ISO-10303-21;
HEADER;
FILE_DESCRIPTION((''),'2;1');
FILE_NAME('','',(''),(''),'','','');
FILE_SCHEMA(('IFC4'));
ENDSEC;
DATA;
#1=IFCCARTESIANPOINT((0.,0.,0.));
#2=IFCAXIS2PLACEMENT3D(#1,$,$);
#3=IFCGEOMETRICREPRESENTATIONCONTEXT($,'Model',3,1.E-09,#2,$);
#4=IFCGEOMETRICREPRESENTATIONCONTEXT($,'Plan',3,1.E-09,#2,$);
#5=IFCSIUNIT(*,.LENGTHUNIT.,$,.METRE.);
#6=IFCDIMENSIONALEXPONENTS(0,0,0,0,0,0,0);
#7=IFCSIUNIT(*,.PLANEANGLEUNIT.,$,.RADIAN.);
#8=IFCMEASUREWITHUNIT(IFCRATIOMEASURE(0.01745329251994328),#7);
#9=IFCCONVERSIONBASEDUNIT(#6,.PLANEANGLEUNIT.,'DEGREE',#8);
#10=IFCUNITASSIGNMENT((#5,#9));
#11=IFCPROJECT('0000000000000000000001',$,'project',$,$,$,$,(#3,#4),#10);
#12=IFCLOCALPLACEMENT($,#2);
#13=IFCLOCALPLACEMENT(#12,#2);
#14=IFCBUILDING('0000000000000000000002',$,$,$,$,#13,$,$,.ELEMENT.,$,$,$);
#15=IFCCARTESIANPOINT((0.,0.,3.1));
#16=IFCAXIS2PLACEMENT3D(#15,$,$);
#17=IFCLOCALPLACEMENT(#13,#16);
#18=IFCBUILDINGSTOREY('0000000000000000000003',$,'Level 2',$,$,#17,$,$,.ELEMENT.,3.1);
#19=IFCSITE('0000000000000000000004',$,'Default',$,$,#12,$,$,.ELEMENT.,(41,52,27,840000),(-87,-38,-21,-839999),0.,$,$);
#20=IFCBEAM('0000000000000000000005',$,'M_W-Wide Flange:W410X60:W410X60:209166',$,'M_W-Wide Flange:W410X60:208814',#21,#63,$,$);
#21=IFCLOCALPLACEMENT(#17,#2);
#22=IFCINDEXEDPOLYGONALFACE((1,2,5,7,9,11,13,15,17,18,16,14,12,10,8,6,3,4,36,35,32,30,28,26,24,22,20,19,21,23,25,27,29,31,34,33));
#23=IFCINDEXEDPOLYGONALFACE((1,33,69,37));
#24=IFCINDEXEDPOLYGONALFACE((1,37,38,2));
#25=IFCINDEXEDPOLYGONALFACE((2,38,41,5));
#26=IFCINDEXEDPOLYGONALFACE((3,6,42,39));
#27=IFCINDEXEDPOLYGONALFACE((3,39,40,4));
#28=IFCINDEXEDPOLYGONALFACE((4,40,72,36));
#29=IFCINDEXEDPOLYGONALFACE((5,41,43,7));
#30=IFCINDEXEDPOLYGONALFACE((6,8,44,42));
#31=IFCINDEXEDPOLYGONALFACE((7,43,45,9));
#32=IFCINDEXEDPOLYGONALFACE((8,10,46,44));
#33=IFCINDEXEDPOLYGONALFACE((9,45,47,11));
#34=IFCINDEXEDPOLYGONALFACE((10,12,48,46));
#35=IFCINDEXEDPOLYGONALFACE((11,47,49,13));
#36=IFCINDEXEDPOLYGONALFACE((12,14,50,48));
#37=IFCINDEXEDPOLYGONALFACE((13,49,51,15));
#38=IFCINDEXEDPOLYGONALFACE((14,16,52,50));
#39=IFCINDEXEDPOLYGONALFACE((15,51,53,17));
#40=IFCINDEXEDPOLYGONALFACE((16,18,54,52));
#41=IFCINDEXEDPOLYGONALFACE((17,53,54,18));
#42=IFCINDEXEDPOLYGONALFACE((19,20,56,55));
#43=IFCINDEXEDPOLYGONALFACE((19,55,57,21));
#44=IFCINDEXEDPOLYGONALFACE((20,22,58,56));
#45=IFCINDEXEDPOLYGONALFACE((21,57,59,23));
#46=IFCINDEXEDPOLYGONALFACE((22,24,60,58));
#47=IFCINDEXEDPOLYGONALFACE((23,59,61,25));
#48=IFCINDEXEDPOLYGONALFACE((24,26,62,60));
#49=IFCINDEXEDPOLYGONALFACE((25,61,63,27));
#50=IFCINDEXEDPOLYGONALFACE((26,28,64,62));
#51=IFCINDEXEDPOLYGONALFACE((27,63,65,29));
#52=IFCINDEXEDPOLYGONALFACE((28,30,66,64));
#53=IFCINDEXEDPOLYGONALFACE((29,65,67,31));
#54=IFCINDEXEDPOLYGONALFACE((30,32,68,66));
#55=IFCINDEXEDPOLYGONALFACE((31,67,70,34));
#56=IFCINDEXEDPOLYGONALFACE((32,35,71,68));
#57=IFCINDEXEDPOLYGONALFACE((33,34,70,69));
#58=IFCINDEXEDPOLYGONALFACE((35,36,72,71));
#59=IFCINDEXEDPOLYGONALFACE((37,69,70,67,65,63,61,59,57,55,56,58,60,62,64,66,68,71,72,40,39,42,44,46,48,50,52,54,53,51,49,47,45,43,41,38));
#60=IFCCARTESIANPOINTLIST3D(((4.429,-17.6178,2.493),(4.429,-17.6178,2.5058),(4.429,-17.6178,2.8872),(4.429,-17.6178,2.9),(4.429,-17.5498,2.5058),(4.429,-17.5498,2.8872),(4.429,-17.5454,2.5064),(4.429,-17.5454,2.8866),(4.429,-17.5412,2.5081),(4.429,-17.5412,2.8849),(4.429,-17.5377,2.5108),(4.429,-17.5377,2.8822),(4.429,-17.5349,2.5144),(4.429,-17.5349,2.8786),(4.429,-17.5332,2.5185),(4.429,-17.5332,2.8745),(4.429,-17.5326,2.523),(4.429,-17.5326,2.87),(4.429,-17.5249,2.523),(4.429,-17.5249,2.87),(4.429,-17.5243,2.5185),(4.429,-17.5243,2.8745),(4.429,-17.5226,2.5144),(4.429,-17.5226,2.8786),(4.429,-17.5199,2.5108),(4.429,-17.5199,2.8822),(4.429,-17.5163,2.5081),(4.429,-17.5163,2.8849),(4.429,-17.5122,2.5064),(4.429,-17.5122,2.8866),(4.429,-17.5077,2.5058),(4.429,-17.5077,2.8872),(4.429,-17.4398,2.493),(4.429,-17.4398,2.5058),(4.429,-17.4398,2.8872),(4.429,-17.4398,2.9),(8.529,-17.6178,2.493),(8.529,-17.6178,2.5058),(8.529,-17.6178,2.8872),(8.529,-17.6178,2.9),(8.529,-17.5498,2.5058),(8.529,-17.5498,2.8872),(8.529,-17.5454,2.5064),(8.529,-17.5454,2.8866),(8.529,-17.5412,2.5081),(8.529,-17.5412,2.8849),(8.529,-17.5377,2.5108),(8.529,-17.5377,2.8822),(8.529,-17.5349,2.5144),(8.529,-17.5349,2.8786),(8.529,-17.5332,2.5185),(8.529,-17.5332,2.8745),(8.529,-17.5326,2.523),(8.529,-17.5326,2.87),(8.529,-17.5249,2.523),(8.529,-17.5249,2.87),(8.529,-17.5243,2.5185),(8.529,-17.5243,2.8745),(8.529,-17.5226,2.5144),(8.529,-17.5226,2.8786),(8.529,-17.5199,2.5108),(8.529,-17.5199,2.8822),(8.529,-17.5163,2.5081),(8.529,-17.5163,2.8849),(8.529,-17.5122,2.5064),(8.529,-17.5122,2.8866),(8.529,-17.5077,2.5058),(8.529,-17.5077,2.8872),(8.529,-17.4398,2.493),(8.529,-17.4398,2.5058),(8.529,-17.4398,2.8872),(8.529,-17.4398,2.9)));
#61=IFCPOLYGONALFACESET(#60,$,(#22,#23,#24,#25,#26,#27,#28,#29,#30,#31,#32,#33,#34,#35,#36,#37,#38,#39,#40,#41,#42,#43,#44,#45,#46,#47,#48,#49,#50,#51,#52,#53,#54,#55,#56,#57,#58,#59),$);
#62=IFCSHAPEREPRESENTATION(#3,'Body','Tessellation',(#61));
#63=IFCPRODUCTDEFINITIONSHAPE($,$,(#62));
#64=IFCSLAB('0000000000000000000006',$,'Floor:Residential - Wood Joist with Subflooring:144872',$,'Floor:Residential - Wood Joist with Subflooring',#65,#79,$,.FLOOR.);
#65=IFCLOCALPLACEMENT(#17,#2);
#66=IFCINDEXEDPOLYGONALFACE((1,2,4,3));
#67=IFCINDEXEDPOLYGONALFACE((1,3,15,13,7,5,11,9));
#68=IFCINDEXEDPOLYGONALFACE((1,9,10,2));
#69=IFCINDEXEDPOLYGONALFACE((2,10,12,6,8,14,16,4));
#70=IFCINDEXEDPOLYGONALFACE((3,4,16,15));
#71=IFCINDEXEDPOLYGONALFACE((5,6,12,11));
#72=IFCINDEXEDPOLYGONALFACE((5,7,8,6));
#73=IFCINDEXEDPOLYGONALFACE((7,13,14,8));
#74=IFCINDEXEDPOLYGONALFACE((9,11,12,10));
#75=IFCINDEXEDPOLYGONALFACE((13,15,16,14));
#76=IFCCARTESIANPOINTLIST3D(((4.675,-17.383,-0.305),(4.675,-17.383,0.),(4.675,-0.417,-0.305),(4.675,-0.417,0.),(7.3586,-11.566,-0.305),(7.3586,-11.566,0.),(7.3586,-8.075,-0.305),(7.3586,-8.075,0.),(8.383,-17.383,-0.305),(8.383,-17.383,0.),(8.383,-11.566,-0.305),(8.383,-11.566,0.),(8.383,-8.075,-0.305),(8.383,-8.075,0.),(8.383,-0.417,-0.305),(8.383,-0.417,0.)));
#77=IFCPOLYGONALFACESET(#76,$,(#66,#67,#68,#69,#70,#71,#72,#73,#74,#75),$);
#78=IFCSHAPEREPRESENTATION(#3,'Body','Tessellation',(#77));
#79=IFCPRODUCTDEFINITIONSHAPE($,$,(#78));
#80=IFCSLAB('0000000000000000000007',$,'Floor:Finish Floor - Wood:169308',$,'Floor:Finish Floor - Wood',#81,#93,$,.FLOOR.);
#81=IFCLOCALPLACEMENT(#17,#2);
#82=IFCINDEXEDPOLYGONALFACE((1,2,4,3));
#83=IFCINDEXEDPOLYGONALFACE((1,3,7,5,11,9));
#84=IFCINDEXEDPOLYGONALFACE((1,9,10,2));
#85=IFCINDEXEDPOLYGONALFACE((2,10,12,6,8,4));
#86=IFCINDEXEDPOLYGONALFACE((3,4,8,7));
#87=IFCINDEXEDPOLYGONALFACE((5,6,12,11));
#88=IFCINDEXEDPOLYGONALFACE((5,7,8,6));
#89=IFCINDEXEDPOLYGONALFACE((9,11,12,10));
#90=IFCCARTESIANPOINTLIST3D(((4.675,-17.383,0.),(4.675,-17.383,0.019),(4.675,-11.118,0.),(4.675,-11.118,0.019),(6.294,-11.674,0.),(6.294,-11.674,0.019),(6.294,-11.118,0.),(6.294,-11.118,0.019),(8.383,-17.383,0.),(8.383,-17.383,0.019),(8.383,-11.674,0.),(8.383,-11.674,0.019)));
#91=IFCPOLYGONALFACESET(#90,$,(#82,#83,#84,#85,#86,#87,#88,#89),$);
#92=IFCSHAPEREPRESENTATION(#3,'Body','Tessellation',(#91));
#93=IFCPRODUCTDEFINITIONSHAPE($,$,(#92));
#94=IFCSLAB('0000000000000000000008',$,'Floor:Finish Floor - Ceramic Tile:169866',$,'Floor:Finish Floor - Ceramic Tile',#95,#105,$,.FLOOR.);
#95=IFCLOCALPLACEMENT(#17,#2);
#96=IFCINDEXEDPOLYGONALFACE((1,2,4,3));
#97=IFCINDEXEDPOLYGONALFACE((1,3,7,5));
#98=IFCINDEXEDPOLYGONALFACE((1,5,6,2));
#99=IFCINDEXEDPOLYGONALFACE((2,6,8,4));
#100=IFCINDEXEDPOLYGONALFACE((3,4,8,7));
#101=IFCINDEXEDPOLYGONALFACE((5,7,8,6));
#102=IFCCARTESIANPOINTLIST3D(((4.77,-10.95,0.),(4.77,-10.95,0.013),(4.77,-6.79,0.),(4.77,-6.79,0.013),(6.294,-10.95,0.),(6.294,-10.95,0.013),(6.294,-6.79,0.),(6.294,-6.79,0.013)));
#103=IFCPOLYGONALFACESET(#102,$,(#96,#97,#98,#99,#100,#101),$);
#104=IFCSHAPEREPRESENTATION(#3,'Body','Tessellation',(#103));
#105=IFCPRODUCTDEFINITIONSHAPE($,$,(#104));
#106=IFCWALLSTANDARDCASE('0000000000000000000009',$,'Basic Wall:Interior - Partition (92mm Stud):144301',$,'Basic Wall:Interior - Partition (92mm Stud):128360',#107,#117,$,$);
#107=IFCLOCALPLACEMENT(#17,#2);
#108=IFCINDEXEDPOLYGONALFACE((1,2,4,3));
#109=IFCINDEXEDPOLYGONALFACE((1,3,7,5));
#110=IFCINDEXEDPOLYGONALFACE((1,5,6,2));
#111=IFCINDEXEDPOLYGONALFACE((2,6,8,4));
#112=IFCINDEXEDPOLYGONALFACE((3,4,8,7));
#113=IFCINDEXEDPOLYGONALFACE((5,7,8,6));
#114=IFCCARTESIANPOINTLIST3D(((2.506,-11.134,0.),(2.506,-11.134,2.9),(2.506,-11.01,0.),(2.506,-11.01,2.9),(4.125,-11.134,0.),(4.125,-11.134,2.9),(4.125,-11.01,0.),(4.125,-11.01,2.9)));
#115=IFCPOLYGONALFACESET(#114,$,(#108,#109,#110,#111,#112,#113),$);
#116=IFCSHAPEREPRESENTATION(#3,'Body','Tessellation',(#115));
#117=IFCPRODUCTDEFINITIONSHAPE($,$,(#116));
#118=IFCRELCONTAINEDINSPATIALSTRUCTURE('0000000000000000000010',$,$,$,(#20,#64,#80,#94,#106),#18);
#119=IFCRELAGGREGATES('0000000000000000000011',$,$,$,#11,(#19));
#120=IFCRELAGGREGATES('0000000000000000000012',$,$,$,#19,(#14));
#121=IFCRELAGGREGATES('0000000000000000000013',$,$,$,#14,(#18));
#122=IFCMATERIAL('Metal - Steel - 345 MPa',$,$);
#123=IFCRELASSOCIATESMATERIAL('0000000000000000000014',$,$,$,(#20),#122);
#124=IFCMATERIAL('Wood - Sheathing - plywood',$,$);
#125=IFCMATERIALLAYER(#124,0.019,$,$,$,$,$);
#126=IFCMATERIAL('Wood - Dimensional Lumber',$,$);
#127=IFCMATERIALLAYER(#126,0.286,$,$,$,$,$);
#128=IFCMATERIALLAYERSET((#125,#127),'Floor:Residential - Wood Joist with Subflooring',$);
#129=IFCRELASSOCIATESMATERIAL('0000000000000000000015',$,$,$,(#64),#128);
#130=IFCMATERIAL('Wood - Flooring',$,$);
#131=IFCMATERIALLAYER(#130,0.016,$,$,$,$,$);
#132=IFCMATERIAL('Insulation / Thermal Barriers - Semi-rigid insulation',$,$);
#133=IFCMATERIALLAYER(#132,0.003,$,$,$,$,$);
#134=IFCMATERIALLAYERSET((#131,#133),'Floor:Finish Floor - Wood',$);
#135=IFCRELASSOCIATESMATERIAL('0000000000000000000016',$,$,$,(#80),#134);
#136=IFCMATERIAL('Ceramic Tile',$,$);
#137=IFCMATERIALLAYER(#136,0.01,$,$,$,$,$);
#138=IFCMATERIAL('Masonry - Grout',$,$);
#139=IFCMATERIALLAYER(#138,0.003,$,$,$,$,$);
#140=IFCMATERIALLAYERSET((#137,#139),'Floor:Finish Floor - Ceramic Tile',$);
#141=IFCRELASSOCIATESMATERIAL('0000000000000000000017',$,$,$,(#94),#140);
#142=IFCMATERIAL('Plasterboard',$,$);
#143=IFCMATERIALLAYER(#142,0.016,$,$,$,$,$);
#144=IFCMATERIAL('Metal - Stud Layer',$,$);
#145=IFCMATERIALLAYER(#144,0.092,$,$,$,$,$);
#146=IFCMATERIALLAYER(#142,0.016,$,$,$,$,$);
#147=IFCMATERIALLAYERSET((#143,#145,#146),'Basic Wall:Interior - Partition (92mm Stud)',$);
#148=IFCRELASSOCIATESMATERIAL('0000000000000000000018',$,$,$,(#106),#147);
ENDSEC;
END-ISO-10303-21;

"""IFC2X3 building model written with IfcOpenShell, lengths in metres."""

from ifc_helpers import new_model, entity, si_unit, converted_unit, frame, frame_2d, origin, place, context, project, spatial, polyline, circle_curve, parameter, trimmed, segment, composite_curve, rectangle, outline, extrude, material, layer, layer_set, layer_usage, element, save


model = new_model("IFC2X3")

# Units and contexts
model_context = context("Model", 3, precision=1e-09, world=origin())
plan_context = context("Plan", 3, precision=1e-09, world=origin())
ifc_project = project(units=[si_unit("LENGTHUNIT", "METRE"), converted_unit("PLANEANGLEUNIT", "DEGREE", entity("IfcRatioMeasure", 0.01745329251994328), si_unit("PLANEANGLEUNIT", "RADIAN"), dimensions=[0, 0, 0, 0, 0, 0, 0])], contexts=[model_context, plan_context])

# Site, building, storey
site_placement = place(None, origin())
site = spatial("IfcSite", under=ifc_project, at=site_placement, Name="Default", CompositionType="ELEMENT", RefLatitude=(41, 52, 27, 840000), RefLongitude=(-87, -38, -21, -839999), RefElevation=0.0)
building_placement = place(site_placement, origin())
building = spatial("IfcBuilding", under=site, at=building_placement, CompositionType="ELEMENT")
storey_placement = place(building_placement, frame((0.0, 0.0, 3.1)))
storey = spatial("IfcBuildingStorey", under=building, at=storey_placement, Name="Level 2", CompositionType="ELEMENT", Elevation=3.1)

# Beam
ifc_material_1 = material(Name="Metal - Steel - 345 MPa")
beam_placement = place(storey_placement, frame((4.429, -17.5288, 2.9), z_axis=(0.0, 0.0, 1.0), x_axis=(0.0, -1.0, 0.0)))
element("IfcBeam", 1, at=beam_placement, inside=storey, material=ifc_material_1, Name="M_W-Wide Flange:W410X60:W410X60:209166", ObjectType="M_W-Wide Flange:W410X60:208814", context=model_context, shape_type="SweptSolid", body=[
    extrude(outline(composite_curve([segment(polyline([(-0.089, -0.1907), (-0.089, -0.2035)]), True, "CONTINUOUS"), segment(polyline([(-0.089, -0.2035), (0.089, -0.2035)]), True, "CONTINUOUS"), segment(polyline([(0.089, -0.2035), (0.089, -0.1907)]), True, "CONTINUOUS"), segment(polyline([(0.089, -0.1907), (0.021, -0.1907)]), True, "CONTINUOUS"), segment(trimmed(circle_curve(frame_2d((0.021, -0.1735), x_axis=(0.0, -1.0)), 0.0172), [parameter(270.0)], [parameter(360.0)], True, "PARAMETER"), False, "CONTINUOUS"), segment(polyline([(0.0038, -0.1735), (0.0038, 0.1735)]), True, "CONTINUOUS"), segment(trimmed(circle_curve(frame_2d((0.021, 0.1735), x_axis=(-1.0, 0.0)), 0.0172), [parameter(270.0)], [parameter(360.0)], True, "PARAMETER"), False, "CONTINUOUS"), segment(polyline([(0.021, 0.1907), (0.089, 0.1907)]), True, "CONTINUOUS"), segment(polyline([(0.089, 0.1907), (0.089, 0.2035)]), True, "CONTINUOUS"), segment(polyline([(0.089, 0.2035), (-0.089, 0.2035)]), True, "CONTINUOUS"), segment(polyline([(-0.089, 0.2035), (-0.089, 0.1907)]), True, "CONTINUOUS"), segment(polyline([(-0.089, 0.1907), (-0.0211, 0.1907)]), True, "CONTINUOUS"), segment(trimmed(circle_curve(frame_2d((-0.0211, 0.1735), x_axis=(0.0, 1.0)), 0.0172), [parameter(270.0)], [parameter(0.0)], True, "PARAMETER"), False, "CONTINUOUS"), segment(polyline([(-0.0039, 0.1735), (-0.0039, -0.1735)]), True, "CONTINUOUS"), segment(trimmed(circle_curve(frame_2d((-0.0211, -0.1735), x_axis=(1.0, 0.0)), 0.0172), [parameter(270.0)], [parameter(0.0)], True, "PARAMETER"), False, "CONTINUOUS"), segment(polyline([(-0.0211, -0.1907), (-0.089, -0.1907)]), True, "CONTINUOUS")], self_intersect=False)), frame((0.0, 0.0, -0.2035), z_axis=(0.0, -1.0, 0.0), x_axis=(1.0, 0.0, 0.0)), (0.0, 0.0, -1.0), 4.1),
])

# Slabs
ifc_material_2 = material(Name="Wood - Sheathing - plywood")
ifc_layer_1 = layer(ifc_material_2, 0.019)
ifc_material_3 = material(Name="Wood - Dimensional Lumber")
ifc_layer_2 = layer(ifc_material_3, 0.286)
ifc_layer_set_1 = layer_set([ifc_layer_1, ifc_layer_2], Name="Floor:Residential - Wood Joist with Subflooring")
ifc_layer_usage_1 = layer_usage(ifc_layer_set_1, "AXIS3", "POSITIVE", 0.0)
slab_1_placement = place(storey_placement, frame((4.675, -17.383, -0.305)))
element("IfcSlab", 2, at=slab_1_placement, inside=storey, material=ifc_layer_usage_1, Name="Floor:Residential - Wood Joist with Subflooring:144872", ObjectType="Floor:Residential - Wood Joist with Subflooring", PredefinedType="FLOOR", context=model_context, shape_type="SweptSolid", body=[
    extrude(outline(polyline([(-1.854, 8.483), (-1.854, 0.825), (-0.8296, 0.825), (-0.8296, -2.666), (-1.854, -2.666), (-1.854, -8.483), (1.854, -8.483), (1.854, 8.483), (-1.854, 8.483)])), frame((1.854, 8.483, 0.305), z_axis=(0.0, 0.0, -1.0), x_axis=(-1.0, 0.0, 0.0)), (0.0, 0.0, 1.0), 0.305),
])
ifc_material_4 = material(Name="Wood - Flooring")
ifc_layer_3 = layer(ifc_material_4, 0.016)
ifc_material_5 = material(Name="Insulation / Thermal Barriers - Semi-rigid insulation")
ifc_layer_4 = layer(ifc_material_5, 0.003)
ifc_layer_set_2 = layer_set([ifc_layer_3, ifc_layer_4], Name="Floor:Finish Floor - Wood")
ifc_layer_usage_2 = layer_usage(ifc_layer_set_2, "AXIS3", "POSITIVE", 0.0)
slab_2_placement = place(storey_placement, frame((4.675, -17.383, 0.0)))
element("IfcSlab", 3, at=slab_2_placement, inside=storey, material=ifc_layer_usage_2, Name="Floor:Finish Floor - Wood:169308", ObjectType="Floor:Finish Floor - Wood", PredefinedType="FLOOR", context=model_context, shape_type="SweptSolid", body=[
    extrude(outline(polyline([(-1.854, 2.5765), (-1.854, -3.1325), (1.854, -3.1325), (1.854, 3.1325), (0.235, 3.1325), (0.235, 2.5765), (-1.854, 2.5765)])), frame((1.854, 3.1325, 0.019), z_axis=(0.0, 0.0, -1.0), x_axis=(-1.0, 0.0, 0.0)), (0.0, 0.0, 1.0), 0.019),
])
ifc_material_6 = material(Name="Ceramic Tile")
ifc_layer_5 = layer(ifc_material_6, 0.01)
ifc_material_7 = material(Name="Masonry - Grout")
ifc_layer_6 = layer(ifc_material_7, 0.003)
ifc_layer_set_3 = layer_set([ifc_layer_5, ifc_layer_6], Name="Floor:Finish Floor - Ceramic Tile")
ifc_layer_usage_3 = layer_usage(ifc_layer_set_3, "AXIS3", "POSITIVE", 0.0)
slab_3_placement = place(storey_placement, frame((4.77, -10.95, 0.0)))
element("IfcSlab", 4, at=slab_3_placement, inside=storey, material=ifc_layer_usage_3, Name="Floor:Finish Floor - Ceramic Tile:169866", ObjectType="Floor:Finish Floor - Ceramic Tile", PredefinedType="FLOOR", context=model_context, shape_type="SweptSolid", body=[
    extrude(rectangle(XDim=4.16, YDim=1.524, at=frame_2d((0.0, 0.0), x_axis=(0.0, -1.0))), frame((0.762, 2.08, 0.013), z_axis=(0.0, 0.0, -1.0), x_axis=(-1.0, 0.0, 0.0)), (0.0, 0.0, 1.0), 0.013),
])

# Shared definitions
ifc_material_8 = material(Name="Metal - Stud Layer")
ifc_material_9 = material(Name="Plasterboard")

# Wall
ifc_layer_7 = layer(ifc_material_9, 0.016)
ifc_layer_8 = layer(ifc_material_8, 0.092)
ifc_layer_9 = layer(ifc_material_9, 0.016)
ifc_layer_set_4 = layer_set([ifc_layer_7, ifc_layer_8, ifc_layer_9], Name="Basic Wall:Interior - Partition (92mm Stud)")
ifc_layer_usage_4 = layer_usage(ifc_layer_set_4, "AXIS2", "NEGATIVE", 0.062)
wall_1_placement = place(storey_placement, frame((4.125, -11.072, 0.0), z_axis=(0.0, 0.0, 1.0), x_axis=(-1.0, 0.0, 0.0)))
element("IfcWallStandardCase", 5, at=wall_1_placement, inside=storey, material=ifc_layer_usage_4, Name="Basic Wall:Interior - Partition (92mm Stud):144301", ObjectType="Basic Wall:Interior - Partition (92mm Stud):128360", context=model_context, shape_type="SweptSolid", body=[
    extrude(rectangle(XDim=1.619, YDim=0.124, at=frame_2d((0.8095, 0.0), x_axis=(-1.0, 0.0))), origin(), (0.0, 0.0, 1.0), 2.9),
])

save(model, "model.ifc")
